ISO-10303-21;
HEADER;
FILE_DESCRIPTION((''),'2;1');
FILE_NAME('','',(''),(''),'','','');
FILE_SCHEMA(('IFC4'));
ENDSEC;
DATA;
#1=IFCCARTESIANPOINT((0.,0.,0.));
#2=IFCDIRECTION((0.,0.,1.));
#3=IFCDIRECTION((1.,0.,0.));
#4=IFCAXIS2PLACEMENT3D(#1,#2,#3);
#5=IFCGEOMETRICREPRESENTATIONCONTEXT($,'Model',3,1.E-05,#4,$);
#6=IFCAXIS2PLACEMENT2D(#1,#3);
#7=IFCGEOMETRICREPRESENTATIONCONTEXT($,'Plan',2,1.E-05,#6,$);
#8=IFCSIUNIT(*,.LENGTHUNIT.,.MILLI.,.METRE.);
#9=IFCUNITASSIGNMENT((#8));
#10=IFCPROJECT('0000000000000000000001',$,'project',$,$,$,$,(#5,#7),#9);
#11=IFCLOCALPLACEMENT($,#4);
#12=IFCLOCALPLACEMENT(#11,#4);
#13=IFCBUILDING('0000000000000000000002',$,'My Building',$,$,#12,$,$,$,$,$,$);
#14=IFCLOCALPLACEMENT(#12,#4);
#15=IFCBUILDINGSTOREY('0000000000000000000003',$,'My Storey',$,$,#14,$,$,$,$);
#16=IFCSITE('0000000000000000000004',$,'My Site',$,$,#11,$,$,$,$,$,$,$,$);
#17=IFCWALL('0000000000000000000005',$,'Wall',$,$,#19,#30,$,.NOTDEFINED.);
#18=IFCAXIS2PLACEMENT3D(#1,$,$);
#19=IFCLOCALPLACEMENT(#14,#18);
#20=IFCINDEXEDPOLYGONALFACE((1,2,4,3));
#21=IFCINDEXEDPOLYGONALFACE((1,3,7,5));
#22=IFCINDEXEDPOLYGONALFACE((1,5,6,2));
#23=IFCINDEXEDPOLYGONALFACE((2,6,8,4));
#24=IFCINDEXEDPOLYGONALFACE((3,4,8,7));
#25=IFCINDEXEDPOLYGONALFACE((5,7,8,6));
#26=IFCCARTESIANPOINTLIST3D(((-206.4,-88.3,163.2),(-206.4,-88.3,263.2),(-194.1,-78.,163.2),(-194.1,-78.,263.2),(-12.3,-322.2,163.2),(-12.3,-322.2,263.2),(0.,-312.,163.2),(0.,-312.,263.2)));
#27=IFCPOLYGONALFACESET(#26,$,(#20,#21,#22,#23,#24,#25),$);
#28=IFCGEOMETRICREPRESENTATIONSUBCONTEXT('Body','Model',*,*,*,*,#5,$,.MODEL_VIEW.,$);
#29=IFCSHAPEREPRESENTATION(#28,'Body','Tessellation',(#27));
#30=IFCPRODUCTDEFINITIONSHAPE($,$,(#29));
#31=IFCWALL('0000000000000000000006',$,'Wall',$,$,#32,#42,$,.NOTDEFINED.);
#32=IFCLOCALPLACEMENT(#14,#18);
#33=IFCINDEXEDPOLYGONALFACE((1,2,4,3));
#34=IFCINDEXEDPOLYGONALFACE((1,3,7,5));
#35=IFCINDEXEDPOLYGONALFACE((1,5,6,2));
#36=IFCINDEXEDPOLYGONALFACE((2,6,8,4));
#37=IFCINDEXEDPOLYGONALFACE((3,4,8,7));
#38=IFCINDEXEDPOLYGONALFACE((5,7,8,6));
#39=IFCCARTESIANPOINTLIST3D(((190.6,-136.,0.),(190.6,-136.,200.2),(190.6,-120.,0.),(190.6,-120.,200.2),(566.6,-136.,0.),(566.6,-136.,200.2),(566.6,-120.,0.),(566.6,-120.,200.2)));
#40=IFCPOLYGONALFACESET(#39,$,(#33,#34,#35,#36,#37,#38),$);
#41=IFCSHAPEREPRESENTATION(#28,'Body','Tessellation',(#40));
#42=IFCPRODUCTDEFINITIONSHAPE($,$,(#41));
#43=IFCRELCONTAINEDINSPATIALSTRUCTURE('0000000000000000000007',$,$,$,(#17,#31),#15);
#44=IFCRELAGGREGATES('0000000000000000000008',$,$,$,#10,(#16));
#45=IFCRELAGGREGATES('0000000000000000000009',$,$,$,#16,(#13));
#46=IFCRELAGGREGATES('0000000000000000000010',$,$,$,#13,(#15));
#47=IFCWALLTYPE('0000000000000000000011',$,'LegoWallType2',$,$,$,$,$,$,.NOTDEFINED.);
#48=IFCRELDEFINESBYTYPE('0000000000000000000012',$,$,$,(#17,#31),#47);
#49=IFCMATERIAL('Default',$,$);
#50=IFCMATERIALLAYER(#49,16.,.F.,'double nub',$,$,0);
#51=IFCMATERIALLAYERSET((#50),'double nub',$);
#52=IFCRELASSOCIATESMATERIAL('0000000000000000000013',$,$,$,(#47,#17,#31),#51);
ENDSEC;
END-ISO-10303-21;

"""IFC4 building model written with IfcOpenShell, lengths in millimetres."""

from ifc_helpers import new_model, si_unit, frame, frame_2d, origin_with_axes, place, context, subcontext, project, spatial, indexed_curve, outline, extrude, material, layer, layer_set, layer_usage, type_object, element, save


model = new_model("IFC4")

# Units and contexts
model_context = context("Model", 3, precision=1e-05, world=origin_with_axes())
plan_context = context("Plan", 2, precision=1e-05, world=frame_2d((0.0, 0.0, 0.0), x_axis=(1.0, 0.0, 0.0)))
body_context = subcontext(model_context, "Body", "Model", "MODEL_VIEW")
ifc_project = project(units=[si_unit("LENGTHUNIT", "METRE", prefix="MILLI")], contexts=[model_context, plan_context])

# Site, building, storey
site_placement = place(None, origin_with_axes())
site = spatial("IfcSite", under=ifc_project, at=site_placement, Name="My Site")
building_placement = place(site_placement, origin_with_axes())
building = spatial("IfcBuilding", under=site, at=building_placement, Name="My Building")
storey_placement = place(building_placement, origin_with_axes())
storey = spatial("IfcBuildingStorey", under=building, at=storey_placement, Name="My Storey")

# Walls
ifc_material = material(Name="Default")
ifc_layer = layer(ifc_material, 16.0, ventilated=False, Name="double nub", Priority=0)
ifc_layer_set = layer_set([ifc_layer], Name="double nub")
ifc_layer_usage_1 = layer_usage(ifc_layer_set, "AXIS2", "POSITIVE", 0.0)
wall_type = type_object("IfcWallType", Name="LegoWallType2", PredefinedType="NOTDEFINED", material=ifc_layer_set)
wall_1_placement = place(storey_placement, frame((0.0, -312.0, 163.2), z_axis=(0.0, 0.0, 1.0), x_axis=(-0.638513, 0.769611, 0.0)))
element("IfcWall", 1, at=wall_1_placement, inside=storey, type_object=wall_type, material=ifc_layer_usage_1, Name="Wall", PredefinedType="NOTDEFINED", context=body_context, shape_type="SweptSolid", body=[
    extrude(outline(indexed_curve([(0.0, 0.0), (0.0, 16.0), (304.0, 16.0), (304.0, 0.0), (0.0, 0.0)], self_intersect=False)), origin_with_axes(), (0.0, 0.0, 1.0), 100.0),
])
ifc_layer_usage_2 = layer_usage(ifc_layer_set, "AXIS2", "POSITIVE", 0.0)
wall_2_placement = place(storey_placement, frame((190.6, -136.0, 0.0), z_axis=(0.0, 0.0, 1.0), x_axis=(1.0, 0.0, 0.0)))
element("IfcWall", 2, at=wall_2_placement, inside=storey, type_object=wall_type, material=ifc_layer_usage_2, Name="Wall", PredefinedType="NOTDEFINED", context=body_context, shape_type="SweptSolid", body=[
    extrude(outline(indexed_curve([(0.0, 0.0), (0.0, 16.0), (376.0, 16.0), (376.0, 0.0), (0.0, 0.0)], self_intersect=False)), origin_with_axes(), (0.0, 0.0, 1.0), 200.2),
])

save(model, "model.ifc")
